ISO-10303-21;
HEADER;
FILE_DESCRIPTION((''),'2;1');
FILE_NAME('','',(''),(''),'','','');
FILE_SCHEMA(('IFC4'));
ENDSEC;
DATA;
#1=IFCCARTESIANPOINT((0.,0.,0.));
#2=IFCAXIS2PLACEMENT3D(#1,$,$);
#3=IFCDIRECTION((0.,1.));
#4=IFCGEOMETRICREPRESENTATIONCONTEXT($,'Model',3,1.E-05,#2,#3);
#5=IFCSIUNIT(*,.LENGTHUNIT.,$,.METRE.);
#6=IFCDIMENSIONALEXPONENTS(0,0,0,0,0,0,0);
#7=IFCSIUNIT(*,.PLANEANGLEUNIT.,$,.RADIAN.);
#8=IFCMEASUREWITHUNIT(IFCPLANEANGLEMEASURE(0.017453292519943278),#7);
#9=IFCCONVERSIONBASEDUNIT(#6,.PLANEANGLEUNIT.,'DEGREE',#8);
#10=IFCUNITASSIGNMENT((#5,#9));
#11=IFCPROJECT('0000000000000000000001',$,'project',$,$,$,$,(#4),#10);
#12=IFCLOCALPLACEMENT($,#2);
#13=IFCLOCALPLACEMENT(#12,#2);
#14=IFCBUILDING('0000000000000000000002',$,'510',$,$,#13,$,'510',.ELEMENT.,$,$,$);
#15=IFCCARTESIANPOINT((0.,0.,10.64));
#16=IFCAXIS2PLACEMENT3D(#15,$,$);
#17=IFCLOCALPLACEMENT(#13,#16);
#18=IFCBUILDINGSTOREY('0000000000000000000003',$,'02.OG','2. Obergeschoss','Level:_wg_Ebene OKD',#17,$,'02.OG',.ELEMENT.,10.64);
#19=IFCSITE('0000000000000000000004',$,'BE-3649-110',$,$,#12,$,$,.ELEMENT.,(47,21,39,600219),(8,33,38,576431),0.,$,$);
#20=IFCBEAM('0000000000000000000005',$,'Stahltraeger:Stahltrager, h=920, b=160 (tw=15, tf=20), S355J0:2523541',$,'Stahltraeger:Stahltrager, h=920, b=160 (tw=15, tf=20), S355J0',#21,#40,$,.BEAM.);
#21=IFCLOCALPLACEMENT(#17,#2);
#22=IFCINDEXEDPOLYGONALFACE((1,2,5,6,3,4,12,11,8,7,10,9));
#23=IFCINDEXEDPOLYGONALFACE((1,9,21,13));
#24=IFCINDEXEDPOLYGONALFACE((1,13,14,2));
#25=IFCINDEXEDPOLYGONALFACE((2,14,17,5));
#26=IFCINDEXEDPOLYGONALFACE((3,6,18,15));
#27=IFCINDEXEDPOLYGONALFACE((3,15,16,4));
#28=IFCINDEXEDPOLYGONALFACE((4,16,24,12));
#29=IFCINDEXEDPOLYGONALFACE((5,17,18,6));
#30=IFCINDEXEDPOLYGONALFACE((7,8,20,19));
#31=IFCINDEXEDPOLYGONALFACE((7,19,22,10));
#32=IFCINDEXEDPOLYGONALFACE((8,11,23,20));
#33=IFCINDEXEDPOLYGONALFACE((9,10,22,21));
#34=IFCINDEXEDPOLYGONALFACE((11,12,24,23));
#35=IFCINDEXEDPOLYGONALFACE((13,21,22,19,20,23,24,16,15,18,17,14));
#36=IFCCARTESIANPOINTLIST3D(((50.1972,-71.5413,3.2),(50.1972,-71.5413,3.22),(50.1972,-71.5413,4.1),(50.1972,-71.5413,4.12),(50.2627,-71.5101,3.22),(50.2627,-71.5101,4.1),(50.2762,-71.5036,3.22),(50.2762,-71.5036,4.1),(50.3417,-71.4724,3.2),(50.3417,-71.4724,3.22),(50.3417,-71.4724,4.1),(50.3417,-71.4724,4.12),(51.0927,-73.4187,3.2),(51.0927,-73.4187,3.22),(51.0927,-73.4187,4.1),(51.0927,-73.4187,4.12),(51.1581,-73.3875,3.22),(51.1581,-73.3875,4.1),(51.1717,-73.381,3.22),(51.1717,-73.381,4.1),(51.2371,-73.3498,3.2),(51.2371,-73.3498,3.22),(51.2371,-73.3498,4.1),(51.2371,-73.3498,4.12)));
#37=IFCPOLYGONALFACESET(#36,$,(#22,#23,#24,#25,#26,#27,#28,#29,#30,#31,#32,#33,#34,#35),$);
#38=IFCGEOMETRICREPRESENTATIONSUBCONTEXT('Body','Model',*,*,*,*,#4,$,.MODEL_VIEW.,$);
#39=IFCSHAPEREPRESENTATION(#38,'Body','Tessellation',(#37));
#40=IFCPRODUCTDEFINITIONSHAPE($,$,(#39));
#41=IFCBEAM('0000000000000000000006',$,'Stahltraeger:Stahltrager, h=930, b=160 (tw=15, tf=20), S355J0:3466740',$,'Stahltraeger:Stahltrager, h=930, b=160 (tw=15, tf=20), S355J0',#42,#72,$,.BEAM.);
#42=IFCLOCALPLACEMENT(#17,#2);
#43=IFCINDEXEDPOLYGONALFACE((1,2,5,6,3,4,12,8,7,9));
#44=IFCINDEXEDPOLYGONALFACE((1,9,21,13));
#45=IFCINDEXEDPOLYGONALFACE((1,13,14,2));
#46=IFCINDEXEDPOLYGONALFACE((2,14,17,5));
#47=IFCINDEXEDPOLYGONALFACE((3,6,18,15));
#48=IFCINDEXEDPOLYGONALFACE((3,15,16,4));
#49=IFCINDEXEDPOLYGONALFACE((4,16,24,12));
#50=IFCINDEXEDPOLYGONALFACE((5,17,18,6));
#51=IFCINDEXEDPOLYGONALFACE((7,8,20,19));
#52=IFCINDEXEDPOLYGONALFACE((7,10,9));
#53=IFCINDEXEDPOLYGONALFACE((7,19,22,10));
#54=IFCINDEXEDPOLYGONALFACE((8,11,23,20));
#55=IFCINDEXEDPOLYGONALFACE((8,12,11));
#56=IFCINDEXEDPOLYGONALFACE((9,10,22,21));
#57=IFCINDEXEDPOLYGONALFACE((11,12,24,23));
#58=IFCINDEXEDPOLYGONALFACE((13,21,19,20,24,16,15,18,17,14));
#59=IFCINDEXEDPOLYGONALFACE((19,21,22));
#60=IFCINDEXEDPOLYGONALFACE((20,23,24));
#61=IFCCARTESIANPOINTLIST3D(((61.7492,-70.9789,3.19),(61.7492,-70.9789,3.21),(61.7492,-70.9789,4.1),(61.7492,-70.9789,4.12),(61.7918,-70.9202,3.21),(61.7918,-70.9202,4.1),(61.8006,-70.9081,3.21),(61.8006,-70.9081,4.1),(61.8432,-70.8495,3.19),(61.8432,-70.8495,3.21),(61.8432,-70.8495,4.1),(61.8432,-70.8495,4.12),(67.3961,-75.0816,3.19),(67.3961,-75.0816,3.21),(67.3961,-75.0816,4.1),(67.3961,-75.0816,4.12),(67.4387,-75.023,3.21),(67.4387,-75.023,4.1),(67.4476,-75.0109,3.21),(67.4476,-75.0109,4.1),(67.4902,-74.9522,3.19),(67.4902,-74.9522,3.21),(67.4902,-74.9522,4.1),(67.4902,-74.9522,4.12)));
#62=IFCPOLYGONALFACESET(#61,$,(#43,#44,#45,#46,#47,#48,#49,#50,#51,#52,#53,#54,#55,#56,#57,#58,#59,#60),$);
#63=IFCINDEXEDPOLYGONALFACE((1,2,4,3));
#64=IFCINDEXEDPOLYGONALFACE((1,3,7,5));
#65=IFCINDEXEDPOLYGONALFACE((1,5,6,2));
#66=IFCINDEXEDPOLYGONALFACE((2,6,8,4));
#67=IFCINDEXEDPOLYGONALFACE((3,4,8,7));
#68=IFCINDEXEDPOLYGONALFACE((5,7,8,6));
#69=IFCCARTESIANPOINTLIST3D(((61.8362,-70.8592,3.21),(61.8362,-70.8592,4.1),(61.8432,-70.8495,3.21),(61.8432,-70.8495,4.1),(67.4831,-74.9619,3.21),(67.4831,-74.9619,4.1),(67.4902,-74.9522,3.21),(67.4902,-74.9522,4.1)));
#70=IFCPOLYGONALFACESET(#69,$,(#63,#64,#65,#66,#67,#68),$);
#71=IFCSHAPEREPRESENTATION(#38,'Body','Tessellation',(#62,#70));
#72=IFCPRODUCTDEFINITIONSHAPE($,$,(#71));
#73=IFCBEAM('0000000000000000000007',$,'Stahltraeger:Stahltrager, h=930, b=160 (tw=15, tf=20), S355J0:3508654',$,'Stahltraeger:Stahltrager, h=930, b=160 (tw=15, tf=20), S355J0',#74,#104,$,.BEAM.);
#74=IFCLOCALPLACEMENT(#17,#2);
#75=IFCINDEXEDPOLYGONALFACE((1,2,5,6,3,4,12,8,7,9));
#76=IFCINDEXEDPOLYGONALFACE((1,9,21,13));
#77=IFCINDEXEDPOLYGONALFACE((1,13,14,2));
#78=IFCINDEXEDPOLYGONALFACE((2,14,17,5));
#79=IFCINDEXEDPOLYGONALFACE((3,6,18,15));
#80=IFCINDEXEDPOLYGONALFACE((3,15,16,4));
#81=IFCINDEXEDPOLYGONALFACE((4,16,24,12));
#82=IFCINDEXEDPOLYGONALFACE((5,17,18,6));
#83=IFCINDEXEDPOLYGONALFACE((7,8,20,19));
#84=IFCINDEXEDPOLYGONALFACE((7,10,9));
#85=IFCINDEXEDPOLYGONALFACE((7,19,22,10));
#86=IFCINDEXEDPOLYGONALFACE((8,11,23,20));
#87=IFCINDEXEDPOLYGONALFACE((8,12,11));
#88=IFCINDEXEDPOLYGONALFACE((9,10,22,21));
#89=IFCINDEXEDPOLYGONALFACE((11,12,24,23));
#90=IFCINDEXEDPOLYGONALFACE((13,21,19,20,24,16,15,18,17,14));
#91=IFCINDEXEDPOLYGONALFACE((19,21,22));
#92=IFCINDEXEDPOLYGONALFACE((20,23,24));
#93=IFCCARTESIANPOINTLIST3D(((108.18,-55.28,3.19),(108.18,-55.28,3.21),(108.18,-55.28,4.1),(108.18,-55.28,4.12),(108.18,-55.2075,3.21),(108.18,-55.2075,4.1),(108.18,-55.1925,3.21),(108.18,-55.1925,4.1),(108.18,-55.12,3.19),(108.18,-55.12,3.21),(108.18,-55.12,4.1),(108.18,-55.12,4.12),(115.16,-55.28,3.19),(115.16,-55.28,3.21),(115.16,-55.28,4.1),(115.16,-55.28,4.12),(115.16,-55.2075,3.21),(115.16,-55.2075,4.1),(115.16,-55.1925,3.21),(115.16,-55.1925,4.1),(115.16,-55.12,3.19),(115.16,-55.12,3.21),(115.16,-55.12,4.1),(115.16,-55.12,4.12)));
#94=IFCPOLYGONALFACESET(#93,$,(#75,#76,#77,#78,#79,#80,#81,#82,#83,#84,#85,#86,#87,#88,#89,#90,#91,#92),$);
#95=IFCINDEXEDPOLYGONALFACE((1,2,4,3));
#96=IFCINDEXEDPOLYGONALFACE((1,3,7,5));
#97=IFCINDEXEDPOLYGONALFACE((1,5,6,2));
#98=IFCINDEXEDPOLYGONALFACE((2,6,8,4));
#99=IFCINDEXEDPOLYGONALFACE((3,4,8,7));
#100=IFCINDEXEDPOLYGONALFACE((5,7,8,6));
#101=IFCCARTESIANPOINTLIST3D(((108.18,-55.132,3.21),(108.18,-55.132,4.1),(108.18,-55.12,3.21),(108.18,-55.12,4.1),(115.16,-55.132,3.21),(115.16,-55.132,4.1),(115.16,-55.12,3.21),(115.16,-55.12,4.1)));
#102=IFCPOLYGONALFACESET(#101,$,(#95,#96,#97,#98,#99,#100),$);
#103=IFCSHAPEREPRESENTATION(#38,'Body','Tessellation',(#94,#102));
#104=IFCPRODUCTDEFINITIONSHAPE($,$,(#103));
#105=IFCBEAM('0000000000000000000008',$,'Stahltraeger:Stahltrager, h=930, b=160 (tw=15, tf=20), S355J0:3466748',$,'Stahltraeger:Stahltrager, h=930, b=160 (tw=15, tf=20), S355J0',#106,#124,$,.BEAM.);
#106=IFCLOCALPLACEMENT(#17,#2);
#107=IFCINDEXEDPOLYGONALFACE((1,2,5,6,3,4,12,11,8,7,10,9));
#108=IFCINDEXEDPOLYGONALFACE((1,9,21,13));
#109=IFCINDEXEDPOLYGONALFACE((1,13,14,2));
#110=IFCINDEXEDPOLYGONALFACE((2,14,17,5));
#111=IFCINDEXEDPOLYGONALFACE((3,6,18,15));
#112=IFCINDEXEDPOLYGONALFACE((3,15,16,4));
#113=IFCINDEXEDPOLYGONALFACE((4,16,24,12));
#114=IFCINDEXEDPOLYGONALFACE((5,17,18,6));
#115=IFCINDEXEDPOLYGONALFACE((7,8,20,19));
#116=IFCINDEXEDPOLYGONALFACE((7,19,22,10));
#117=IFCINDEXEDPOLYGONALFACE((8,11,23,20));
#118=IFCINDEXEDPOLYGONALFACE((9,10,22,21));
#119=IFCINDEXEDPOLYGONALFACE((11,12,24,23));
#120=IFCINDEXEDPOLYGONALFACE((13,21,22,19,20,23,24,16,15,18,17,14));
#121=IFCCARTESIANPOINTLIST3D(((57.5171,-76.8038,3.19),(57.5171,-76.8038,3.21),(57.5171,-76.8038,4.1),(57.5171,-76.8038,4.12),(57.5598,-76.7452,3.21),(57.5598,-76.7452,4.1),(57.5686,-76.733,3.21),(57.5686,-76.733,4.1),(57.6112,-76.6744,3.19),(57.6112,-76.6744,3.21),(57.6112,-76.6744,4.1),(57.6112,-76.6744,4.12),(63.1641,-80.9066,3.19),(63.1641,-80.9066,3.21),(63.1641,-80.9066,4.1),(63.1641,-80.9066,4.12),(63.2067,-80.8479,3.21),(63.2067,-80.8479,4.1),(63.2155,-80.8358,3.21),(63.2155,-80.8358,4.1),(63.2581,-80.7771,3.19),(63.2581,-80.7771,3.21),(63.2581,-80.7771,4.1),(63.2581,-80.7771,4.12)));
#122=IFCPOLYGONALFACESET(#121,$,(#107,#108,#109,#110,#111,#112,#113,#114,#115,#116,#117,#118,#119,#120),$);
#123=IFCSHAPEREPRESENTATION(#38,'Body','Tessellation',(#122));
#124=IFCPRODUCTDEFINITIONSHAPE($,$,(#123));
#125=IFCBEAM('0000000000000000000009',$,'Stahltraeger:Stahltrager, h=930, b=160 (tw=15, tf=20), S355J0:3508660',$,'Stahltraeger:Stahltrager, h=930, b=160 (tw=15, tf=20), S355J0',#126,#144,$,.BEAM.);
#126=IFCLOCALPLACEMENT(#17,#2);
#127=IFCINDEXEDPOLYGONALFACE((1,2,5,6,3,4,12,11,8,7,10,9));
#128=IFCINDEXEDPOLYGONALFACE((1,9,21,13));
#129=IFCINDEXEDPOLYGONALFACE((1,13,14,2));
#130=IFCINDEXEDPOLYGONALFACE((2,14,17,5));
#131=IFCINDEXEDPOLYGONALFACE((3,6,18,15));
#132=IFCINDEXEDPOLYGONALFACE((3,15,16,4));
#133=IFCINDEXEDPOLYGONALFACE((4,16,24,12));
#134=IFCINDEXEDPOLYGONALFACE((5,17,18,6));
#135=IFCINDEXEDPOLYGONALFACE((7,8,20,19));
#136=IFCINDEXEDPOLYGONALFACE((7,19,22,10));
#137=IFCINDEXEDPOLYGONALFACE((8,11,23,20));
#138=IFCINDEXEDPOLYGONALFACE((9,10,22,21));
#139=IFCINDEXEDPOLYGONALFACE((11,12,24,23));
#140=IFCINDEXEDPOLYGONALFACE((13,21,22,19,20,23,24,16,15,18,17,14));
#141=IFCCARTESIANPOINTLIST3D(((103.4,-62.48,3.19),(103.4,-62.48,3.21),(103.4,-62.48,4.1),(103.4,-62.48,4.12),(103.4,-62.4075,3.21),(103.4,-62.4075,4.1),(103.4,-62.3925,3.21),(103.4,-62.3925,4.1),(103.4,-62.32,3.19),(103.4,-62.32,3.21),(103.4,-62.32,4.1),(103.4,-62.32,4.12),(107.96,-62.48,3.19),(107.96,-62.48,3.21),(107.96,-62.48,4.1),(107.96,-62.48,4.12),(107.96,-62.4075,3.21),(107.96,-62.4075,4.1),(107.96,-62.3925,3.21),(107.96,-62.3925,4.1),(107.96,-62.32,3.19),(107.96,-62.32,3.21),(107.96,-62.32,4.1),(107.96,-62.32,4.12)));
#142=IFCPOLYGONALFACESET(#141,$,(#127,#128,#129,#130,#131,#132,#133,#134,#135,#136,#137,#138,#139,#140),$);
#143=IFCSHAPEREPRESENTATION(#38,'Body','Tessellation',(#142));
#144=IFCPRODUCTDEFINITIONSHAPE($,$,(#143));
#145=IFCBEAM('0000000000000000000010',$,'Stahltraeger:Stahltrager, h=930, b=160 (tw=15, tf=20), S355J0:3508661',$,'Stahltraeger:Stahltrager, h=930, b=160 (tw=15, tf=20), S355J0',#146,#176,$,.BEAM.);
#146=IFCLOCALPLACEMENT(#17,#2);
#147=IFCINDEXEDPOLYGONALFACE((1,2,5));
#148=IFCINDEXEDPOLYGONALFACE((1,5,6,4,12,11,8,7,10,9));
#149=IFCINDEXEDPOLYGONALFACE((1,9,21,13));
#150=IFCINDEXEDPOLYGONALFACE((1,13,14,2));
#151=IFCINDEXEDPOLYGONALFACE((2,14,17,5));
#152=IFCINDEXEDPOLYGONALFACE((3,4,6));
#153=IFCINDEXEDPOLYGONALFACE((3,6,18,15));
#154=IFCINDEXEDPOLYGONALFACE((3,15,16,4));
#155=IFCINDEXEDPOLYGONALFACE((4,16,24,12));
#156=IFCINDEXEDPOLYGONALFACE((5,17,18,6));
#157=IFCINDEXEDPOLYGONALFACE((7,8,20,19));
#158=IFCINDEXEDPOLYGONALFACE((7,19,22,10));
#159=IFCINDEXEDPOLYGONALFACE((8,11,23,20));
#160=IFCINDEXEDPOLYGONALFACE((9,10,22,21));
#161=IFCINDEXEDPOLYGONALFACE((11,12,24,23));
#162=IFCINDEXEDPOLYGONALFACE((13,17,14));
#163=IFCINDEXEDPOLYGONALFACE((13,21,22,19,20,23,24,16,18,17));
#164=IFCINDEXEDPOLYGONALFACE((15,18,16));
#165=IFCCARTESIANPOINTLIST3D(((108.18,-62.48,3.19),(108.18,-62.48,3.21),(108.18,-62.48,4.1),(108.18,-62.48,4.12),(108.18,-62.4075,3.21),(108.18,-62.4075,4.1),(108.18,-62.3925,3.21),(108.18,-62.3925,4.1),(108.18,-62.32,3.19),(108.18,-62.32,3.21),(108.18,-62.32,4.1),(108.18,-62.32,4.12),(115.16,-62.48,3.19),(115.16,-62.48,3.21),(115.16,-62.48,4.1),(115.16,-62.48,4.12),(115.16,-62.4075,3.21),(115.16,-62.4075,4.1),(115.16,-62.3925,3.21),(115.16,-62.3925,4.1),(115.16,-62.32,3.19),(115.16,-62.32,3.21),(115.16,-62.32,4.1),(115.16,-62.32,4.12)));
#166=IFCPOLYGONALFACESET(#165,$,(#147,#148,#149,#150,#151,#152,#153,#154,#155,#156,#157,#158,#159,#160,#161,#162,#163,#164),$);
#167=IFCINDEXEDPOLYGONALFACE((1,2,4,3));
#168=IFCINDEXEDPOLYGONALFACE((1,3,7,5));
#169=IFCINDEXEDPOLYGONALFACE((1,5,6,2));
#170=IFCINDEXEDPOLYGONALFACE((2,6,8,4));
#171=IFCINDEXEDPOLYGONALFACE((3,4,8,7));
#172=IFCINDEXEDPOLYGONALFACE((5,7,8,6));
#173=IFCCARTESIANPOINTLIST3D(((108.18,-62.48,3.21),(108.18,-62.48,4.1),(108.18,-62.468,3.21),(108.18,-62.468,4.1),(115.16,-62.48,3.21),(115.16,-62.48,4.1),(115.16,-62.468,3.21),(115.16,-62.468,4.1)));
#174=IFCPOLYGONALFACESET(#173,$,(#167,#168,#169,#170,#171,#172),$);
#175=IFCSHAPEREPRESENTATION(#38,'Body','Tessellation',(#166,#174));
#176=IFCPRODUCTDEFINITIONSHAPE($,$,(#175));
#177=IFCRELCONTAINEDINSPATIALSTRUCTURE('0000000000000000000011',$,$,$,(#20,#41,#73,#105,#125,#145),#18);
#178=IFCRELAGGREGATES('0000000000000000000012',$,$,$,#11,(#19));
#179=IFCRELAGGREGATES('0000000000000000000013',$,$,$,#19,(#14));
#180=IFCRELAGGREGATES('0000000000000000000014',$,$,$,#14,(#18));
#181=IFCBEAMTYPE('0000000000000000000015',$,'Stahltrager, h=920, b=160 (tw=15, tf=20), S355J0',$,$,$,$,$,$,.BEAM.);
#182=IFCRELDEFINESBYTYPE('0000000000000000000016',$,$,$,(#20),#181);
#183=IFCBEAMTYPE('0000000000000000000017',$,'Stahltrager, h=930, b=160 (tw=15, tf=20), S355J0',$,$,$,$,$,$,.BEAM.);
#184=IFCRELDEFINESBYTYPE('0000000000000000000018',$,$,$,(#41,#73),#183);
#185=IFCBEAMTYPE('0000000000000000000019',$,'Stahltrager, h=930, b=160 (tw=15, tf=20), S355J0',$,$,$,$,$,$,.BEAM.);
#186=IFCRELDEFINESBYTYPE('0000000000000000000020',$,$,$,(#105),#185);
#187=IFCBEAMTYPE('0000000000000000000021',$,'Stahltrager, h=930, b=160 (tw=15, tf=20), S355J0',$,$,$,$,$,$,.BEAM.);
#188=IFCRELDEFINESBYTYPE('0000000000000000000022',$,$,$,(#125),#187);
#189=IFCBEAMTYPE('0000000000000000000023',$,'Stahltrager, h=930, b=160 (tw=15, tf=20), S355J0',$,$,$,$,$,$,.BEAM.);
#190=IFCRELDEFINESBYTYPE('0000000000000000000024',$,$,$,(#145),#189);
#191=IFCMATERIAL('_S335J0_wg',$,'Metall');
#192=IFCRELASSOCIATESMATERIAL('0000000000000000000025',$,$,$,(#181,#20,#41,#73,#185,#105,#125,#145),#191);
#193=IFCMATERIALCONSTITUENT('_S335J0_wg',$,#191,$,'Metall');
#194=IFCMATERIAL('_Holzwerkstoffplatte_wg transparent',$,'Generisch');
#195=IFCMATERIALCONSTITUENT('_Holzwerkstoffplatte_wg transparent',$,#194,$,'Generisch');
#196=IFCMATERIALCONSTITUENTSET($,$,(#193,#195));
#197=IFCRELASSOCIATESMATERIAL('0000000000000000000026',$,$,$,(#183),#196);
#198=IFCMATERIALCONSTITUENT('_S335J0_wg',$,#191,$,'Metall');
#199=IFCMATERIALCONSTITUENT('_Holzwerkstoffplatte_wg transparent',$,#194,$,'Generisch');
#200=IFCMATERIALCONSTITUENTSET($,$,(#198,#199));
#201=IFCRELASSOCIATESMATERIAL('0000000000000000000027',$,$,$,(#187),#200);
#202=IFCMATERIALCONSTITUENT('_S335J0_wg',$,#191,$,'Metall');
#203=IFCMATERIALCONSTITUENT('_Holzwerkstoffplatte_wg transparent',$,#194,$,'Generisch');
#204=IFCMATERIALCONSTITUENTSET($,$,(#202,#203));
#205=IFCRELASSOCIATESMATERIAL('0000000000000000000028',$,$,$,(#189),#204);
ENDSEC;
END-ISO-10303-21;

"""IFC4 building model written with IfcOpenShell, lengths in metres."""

from ifc_helpers import new_model, entity, si_unit, converted_unit, direction, frame, origin, place, context, subcontext, project, spatial, indexed_curve, outline, extrude, source, transform, mapped, material, constituent, constituent_set, type_object, type_shapes, element, save


model = new_model("IFC4")

# Units and contexts
model_context = context("Model", 3, precision=1e-05, world=origin(), true_north=direction((0.0, 1.0)))
body_context = subcontext(model_context, "Body", "Model", "MODEL_VIEW")
ifc_project = project(units=[si_unit("LENGTHUNIT", "METRE"), converted_unit("PLANEANGLEUNIT", "DEGREE", entity("IfcPlaneAngleMeasure", 0.017453292519943278), si_unit("PLANEANGLEUNIT", "RADIAN"), dimensions=[0, 0, 0, 0, 0, 0, 0])], contexts=[model_context])

# Site, building, storey
site_placement = place(None, origin())
site = spatial("IfcSite", under=ifc_project, at=site_placement, Name="BE-3649-110", CompositionType="ELEMENT", RefLatitude=(47, 21, 39, 600219), RefLongitude=(8, 33, 38, 576431), RefElevation=0.0)
building_placement = place(site_placement, origin())
building = spatial("IfcBuilding", under=site, at=building_placement, Name="510", LongName="510", CompositionType="ELEMENT")
storey_placement = place(building_placement, frame((0.0, 0.0, 10.64)))
storey = spatial("IfcBuildingStorey", under=building, at=storey_placement, Name="02.OG", Description="2. Obergeschoss", ObjectType="Level:_wg_Ebene OKD", LongName="02.OG", CompositionType="ELEMENT", Elevation=10.64)

# Beam, opening
ifc_material_1 = material(Name="_S335J0_wg", Category="Metall")
beam_type_1 = type_object("IfcBeamType", Name="Stahltrager, h=920, b=160 (tw=15, tf=20), S355J0", PredefinedType="BEAM", material=ifc_material_1)
shared_shape_1 = source(origin(), body_context, "Body", "SweptSolid", [
    extrude(outline(indexed_curve([(-0.08, -0.44), (-0.08, -0.46), (0.08, -0.46), (0.08, -0.44), (0.0075, -0.44), (0.0075, 0.44), (0.08, 0.44), (0.08, 0.46), (-0.08, 0.46), (-0.08, 0.44), (-0.0075, 0.44), (-0.0075, -0.44), (-0.08, -0.44)], self_intersect=False)), frame((0.9677, 0.0344, 0.46), z_axis=(0.430511, -0.902585, 0.0), x_axis=(0.902585, 0.430511, 0.0)), (0.0, 0.0, -1.0), 2.08),
])
type_shapes(beam_type_1, [shared_shape_1])
beam_1_placement = place(storey_placement, frame((50.1972, -73.4187, 3.2)))
beam_1 = element("IfcBeam", 1, at=beam_1_placement, inside=storey, type_object=beam_type_1, material=ifc_material_1, Name="Stahltraeger:Stahltrager, h=920, b=160 (tw=15, tf=20), S355J0:2523541", ObjectType="Stahltraeger:Stahltrager, h=920, b=160 (tw=15, tf=20), S355J0", PredefinedType="BEAM", context=body_context, shape_type="MappedRepresentation", body=[
    mapped(shared_shape_1, transform((0.0, 0.0, 0.0), scale=1.0)),
])
opening_1_placement = place(storey_placement, frame((50.1972, -73.4187, 3.2)))
element("IfcOpeningElement", 2, at=opening_1_placement, cuts=beam_1, PredefinedType="OPENING", context=body_context, shape_type="SweptSolid", body=[
    extrude(outline(indexed_curve([(-0.32, -0.22), (0.32, -0.22), (0.32, 0.22), (-0.32, 0.22), (-0.32, -0.22)], self_intersect=False)), frame((0.5148, 0.9664, -10.2217), z_axis=(0.902585, 0.430511, 0.0), x_axis=(-0.430511, 0.902585, 0.0)), (0.0, 0.0, 1.0), 0.015),
])

# Beams
ifc_constituent_1 = constituent(ifc_material_1, Name="_S335J0_wg", Category="Metall")
ifc_material_2 = material(Name="_Holzwerkstoffplatte_wg transparent", Category="Generisch")
ifc_constituent_2 = constituent(ifc_material_2, Name="_Holzwerkstoffplatte_wg transparent", Category="Generisch")
ifc_constituent_set_1 = constituent_set(constituents=[ifc_constituent_1, ifc_constituent_2])
beam_type_2 = type_object("IfcBeamType", Name="Stahltrager, h=930, b=160 (tw=15, tf=20), S355J0", PredefinedType="BEAM", material=ifc_constituent_set_1)
shared_shape_2 = source(origin(), body_context, "Body", "SweptSolid", [
    extrude(outline(indexed_curve([(-0.465, -0.08), (-0.445, -0.08), (-0.445, -0.0075), (0.445, -0.0075), (0.445, -0.08), (0.465, -0.08), (0.465, 0.08), (0.445, 0.08), (0.445, 0.0075), (-0.445, 0.0075), (-0.445, 0.08), (-0.465, 0.08), (-0.465, -0.08)], self_intersect=False)), frame((-3.49, 0.0, 0.0), z_axis=(1.0, 0.0, 0.0), x_axis=(0.0, 0.0, -1.0)), (0.0, 0.0, 1.0), 6.98),
    extrude(outline(indexed_curve([(-0.445, -0.006), (0.445, -0.006), (0.445, 0.006), (-0.445, 0.006), (-0.445, -0.006)], self_intersect=False)), frame((-3.49, 0.074, 0.0), z_axis=(1.0, 0.0, 0.0), x_axis=(0.0, 0.0, -1.0)), (0.0, 0.0, 1.0), 6.98),
])
type_shapes(beam_type_2, [shared_shape_2])
beam_2_placement = place(storey_placement, frame((64.6197, -72.9655, 3.655), z_axis=(0.0, 0.0, 1.0), x_axis=(0.809017, -0.587785, 0.0)))
element("IfcBeam", 3, at=beam_2_placement, inside=storey, type_object=beam_type_2, material=ifc_material_1, Name="Stahltraeger:Stahltrager, h=930, b=160 (tw=15, tf=20), S355J0:3466740", ObjectType="Stahltraeger:Stahltrager, h=930, b=160 (tw=15, tf=20), S355J0", PredefinedType="BEAM", context=body_context, shape_type="MappedRepresentation", body=[
    mapped(shared_shape_2, transform((0.0, 0.0, 0.0), scale=1.0)),
])
beam_3_placement = place(storey_placement, frame((111.67, -55.2, 3.655)))
element("IfcBeam", 4, at=beam_3_placement, inside=storey, type_object=beam_type_2, material=ifc_material_1, Name="Stahltraeger:Stahltrager, h=930, b=160 (tw=15, tf=20), S355J0:3508654", ObjectType="Stahltraeger:Stahltrager, h=930, b=160 (tw=15, tf=20), S355J0", PredefinedType="BEAM", context=body_context, shape_type="MappedRepresentation", body=[
    mapped(shared_shape_2, transform((0.0, 0.0, 0.0), scale=1.0)),
])

# Beam, opening
beam_type_3 = type_object("IfcBeamType", Name="Stahltrager, h=930, b=160 (tw=15, tf=20), S355J0", PredefinedType="BEAM", material=ifc_material_1)
shared_shape_3 = source(origin(), body_context, "Body", "SweptSolid", [
    extrude(outline(indexed_curve([(-0.08, -0.445), (-0.08, -0.465), (0.08, -0.465), (0.08, -0.445), (0.0075, -0.445), (0.0075, 0.445), (0.08, 0.445), (0.08, 0.465), (-0.08, 0.465), (-0.08, 0.445), (-0.0075, 0.445), (-0.0075, -0.445), (-0.08, -0.445)], self_intersect=False)), frame((0.047, 4.1675, 0.465), z_axis=(-0.809017, 0.587785, 0.0), x_axis=(-0.587785, -0.809017, 0.0)), (0.0, 0.0, -1.0), 6.98),
])
type_shapes(beam_type_3, [shared_shape_3])
beam_4_placement = place(storey_placement, frame((57.5171, -80.9066, 3.19)))
beam_4 = element("IfcBeam", 5, at=beam_4_placement, inside=storey, type_object=beam_type_3, material=ifc_material_1, Name="Stahltraeger:Stahltrager, h=930, b=160 (tw=15, tf=20), S355J0:3466748", ObjectType="Stahltraeger:Stahltrager, h=930, b=160 (tw=15, tf=20), S355J0", PredefinedType="BEAM", context=body_context, shape_type="MappedRepresentation", body=[
    mapped(shared_shape_3, transform((0.0, 0.0, 0.0), scale=1.0)),
])
opening_2_placement = place(storey_placement, frame((57.5171, -80.9066, 3.19)))
element("IfcOpeningElement", 6, at=opening_2_placement, cuts=beam_4, PredefinedType="OPENING", context=body_context, shape_type="SweptSolid", body=[
    extrude(outline(indexed_curve([(-0.225, -0.15), (0.225, -0.15), (0.225, 0.15), (-0.225, 0.15), (-0.225, -0.15)], self_intersect=False)), frame((4.8165, 0.7115, -10.195), z_axis=(-0.587785, -0.809017, 0.0), x_axis=(-0.809017, 0.587785, 0.0)), (0.0, 0.0, 1.0), 0.015),
])

# Beams
ifc_constituent_3 = constituent(ifc_material_1, Name="_S335J0_wg", Category="Metall")
ifc_constituent_4 = constituent(ifc_material_2, Name="_Holzwerkstoffplatte_wg transparent", Category="Generisch")
ifc_constituent_set_2 = constituent_set(constituents=[ifc_constituent_3, ifc_constituent_4])
beam_type_4 = type_object("IfcBeamType", Name="Stahltrager, h=930, b=160 (tw=15, tf=20), S355J0", PredefinedType="BEAM", material=ifc_constituent_set_2)
shared_shape_4 = source(origin(), body_context, "Body", "SweptSolid", [
    extrude(outline(indexed_curve([(-0.465, -0.08), (-0.445, -0.08), (-0.445, -0.0075), (0.445, -0.0075), (0.445, -0.08), (0.465, -0.08), (0.465, 0.08), (0.445, 0.08), (0.445, 0.0075), (-0.445, 0.0075), (-0.445, 0.08), (-0.465, 0.08), (-0.465, -0.08)], self_intersect=False)), frame((-2.28, 0.0, 0.0), z_axis=(1.0, 0.0, 0.0), x_axis=(0.0, 0.0, -1.0)), (0.0, 0.0, 1.0), 4.56),
])
type_shapes(beam_type_4, [shared_shape_4])
beam_5_placement = place(storey_placement, frame((105.68, -62.4, 3.655)))
element("IfcBeam", 7, at=beam_5_placement, inside=storey, type_object=beam_type_4, material=ifc_material_1, Name="Stahltraeger:Stahltrager, h=930, b=160 (tw=15, tf=20), S355J0:3508660", ObjectType="Stahltraeger:Stahltrager, h=930, b=160 (tw=15, tf=20), S355J0", PredefinedType="BEAM", context=body_context, shape_type="MappedRepresentation", body=[
    mapped(shared_shape_4, transform((0.0, 0.0, 0.0), scale=1.0)),
])
ifc_constituent_5 = constituent(ifc_material_1, Name="_S335J0_wg", Category="Metall")
ifc_constituent_6 = constituent(ifc_material_2, Name="_Holzwerkstoffplatte_wg transparent", Category="Generisch")
ifc_constituent_set_3 = constituent_set(constituents=[ifc_constituent_5, ifc_constituent_6])
beam_type_5 = type_object("IfcBeamType", Name="Stahltrager, h=930, b=160 (tw=15, tf=20), S355J0", PredefinedType="BEAM", material=ifc_constituent_set_3)
shared_shape_5 = source(origin(), body_context, "Body", "SweptSolid", [
    extrude(outline(indexed_curve([(-0.465, -0.08), (-0.445, -0.08), (-0.445, -0.0075), (0.445, -0.0075), (0.445, -0.08), (0.465, -0.08), (0.465, 0.08), (0.445, 0.08), (0.445, 0.0075), (-0.445, 0.0075), (-0.445, 0.08), (-0.465, 0.08), (-0.465, -0.08)], self_intersect=False)), frame((-3.49, 0.0, 0.0), z_axis=(1.0, 0.0, 0.0), x_axis=(0.0, 0.0, -1.0)), (0.0, 0.0, 1.0), 6.98),
    extrude(outline(indexed_curve([(-0.445, -0.006), (0.445, -0.006), (0.445, 0.006), (-0.445, 0.006), (-0.445, -0.006)], self_intersect=False)), frame((-3.49, -0.074, 0.0), z_axis=(1.0, 0.0, 0.0), x_axis=(0.0, 0.0, -1.0)), (0.0, 0.0, 1.0), 6.98),
])
type_shapes(beam_type_5, [shared_shape_5])
beam_6_placement = place(storey_placement, frame((111.67, -62.4, 3.655)))
element("IfcBeam", 8, at=beam_6_placement, inside=storey, type_object=beam_type_5, material=ifc_material_1, Name="Stahltraeger:Stahltrager, h=930, b=160 (tw=15, tf=20), S355J0:3508661", ObjectType="Stahltraeger:Stahltrager, h=930, b=160 (tw=15, tf=20), S355J0", PredefinedType="BEAM", context=body_context, shape_type="MappedRepresentation", body=[
    mapped(shared_shape_5, transform((0.0, 0.0, 0.0), scale=1.0)),
])

save(model, "model.ifc")
